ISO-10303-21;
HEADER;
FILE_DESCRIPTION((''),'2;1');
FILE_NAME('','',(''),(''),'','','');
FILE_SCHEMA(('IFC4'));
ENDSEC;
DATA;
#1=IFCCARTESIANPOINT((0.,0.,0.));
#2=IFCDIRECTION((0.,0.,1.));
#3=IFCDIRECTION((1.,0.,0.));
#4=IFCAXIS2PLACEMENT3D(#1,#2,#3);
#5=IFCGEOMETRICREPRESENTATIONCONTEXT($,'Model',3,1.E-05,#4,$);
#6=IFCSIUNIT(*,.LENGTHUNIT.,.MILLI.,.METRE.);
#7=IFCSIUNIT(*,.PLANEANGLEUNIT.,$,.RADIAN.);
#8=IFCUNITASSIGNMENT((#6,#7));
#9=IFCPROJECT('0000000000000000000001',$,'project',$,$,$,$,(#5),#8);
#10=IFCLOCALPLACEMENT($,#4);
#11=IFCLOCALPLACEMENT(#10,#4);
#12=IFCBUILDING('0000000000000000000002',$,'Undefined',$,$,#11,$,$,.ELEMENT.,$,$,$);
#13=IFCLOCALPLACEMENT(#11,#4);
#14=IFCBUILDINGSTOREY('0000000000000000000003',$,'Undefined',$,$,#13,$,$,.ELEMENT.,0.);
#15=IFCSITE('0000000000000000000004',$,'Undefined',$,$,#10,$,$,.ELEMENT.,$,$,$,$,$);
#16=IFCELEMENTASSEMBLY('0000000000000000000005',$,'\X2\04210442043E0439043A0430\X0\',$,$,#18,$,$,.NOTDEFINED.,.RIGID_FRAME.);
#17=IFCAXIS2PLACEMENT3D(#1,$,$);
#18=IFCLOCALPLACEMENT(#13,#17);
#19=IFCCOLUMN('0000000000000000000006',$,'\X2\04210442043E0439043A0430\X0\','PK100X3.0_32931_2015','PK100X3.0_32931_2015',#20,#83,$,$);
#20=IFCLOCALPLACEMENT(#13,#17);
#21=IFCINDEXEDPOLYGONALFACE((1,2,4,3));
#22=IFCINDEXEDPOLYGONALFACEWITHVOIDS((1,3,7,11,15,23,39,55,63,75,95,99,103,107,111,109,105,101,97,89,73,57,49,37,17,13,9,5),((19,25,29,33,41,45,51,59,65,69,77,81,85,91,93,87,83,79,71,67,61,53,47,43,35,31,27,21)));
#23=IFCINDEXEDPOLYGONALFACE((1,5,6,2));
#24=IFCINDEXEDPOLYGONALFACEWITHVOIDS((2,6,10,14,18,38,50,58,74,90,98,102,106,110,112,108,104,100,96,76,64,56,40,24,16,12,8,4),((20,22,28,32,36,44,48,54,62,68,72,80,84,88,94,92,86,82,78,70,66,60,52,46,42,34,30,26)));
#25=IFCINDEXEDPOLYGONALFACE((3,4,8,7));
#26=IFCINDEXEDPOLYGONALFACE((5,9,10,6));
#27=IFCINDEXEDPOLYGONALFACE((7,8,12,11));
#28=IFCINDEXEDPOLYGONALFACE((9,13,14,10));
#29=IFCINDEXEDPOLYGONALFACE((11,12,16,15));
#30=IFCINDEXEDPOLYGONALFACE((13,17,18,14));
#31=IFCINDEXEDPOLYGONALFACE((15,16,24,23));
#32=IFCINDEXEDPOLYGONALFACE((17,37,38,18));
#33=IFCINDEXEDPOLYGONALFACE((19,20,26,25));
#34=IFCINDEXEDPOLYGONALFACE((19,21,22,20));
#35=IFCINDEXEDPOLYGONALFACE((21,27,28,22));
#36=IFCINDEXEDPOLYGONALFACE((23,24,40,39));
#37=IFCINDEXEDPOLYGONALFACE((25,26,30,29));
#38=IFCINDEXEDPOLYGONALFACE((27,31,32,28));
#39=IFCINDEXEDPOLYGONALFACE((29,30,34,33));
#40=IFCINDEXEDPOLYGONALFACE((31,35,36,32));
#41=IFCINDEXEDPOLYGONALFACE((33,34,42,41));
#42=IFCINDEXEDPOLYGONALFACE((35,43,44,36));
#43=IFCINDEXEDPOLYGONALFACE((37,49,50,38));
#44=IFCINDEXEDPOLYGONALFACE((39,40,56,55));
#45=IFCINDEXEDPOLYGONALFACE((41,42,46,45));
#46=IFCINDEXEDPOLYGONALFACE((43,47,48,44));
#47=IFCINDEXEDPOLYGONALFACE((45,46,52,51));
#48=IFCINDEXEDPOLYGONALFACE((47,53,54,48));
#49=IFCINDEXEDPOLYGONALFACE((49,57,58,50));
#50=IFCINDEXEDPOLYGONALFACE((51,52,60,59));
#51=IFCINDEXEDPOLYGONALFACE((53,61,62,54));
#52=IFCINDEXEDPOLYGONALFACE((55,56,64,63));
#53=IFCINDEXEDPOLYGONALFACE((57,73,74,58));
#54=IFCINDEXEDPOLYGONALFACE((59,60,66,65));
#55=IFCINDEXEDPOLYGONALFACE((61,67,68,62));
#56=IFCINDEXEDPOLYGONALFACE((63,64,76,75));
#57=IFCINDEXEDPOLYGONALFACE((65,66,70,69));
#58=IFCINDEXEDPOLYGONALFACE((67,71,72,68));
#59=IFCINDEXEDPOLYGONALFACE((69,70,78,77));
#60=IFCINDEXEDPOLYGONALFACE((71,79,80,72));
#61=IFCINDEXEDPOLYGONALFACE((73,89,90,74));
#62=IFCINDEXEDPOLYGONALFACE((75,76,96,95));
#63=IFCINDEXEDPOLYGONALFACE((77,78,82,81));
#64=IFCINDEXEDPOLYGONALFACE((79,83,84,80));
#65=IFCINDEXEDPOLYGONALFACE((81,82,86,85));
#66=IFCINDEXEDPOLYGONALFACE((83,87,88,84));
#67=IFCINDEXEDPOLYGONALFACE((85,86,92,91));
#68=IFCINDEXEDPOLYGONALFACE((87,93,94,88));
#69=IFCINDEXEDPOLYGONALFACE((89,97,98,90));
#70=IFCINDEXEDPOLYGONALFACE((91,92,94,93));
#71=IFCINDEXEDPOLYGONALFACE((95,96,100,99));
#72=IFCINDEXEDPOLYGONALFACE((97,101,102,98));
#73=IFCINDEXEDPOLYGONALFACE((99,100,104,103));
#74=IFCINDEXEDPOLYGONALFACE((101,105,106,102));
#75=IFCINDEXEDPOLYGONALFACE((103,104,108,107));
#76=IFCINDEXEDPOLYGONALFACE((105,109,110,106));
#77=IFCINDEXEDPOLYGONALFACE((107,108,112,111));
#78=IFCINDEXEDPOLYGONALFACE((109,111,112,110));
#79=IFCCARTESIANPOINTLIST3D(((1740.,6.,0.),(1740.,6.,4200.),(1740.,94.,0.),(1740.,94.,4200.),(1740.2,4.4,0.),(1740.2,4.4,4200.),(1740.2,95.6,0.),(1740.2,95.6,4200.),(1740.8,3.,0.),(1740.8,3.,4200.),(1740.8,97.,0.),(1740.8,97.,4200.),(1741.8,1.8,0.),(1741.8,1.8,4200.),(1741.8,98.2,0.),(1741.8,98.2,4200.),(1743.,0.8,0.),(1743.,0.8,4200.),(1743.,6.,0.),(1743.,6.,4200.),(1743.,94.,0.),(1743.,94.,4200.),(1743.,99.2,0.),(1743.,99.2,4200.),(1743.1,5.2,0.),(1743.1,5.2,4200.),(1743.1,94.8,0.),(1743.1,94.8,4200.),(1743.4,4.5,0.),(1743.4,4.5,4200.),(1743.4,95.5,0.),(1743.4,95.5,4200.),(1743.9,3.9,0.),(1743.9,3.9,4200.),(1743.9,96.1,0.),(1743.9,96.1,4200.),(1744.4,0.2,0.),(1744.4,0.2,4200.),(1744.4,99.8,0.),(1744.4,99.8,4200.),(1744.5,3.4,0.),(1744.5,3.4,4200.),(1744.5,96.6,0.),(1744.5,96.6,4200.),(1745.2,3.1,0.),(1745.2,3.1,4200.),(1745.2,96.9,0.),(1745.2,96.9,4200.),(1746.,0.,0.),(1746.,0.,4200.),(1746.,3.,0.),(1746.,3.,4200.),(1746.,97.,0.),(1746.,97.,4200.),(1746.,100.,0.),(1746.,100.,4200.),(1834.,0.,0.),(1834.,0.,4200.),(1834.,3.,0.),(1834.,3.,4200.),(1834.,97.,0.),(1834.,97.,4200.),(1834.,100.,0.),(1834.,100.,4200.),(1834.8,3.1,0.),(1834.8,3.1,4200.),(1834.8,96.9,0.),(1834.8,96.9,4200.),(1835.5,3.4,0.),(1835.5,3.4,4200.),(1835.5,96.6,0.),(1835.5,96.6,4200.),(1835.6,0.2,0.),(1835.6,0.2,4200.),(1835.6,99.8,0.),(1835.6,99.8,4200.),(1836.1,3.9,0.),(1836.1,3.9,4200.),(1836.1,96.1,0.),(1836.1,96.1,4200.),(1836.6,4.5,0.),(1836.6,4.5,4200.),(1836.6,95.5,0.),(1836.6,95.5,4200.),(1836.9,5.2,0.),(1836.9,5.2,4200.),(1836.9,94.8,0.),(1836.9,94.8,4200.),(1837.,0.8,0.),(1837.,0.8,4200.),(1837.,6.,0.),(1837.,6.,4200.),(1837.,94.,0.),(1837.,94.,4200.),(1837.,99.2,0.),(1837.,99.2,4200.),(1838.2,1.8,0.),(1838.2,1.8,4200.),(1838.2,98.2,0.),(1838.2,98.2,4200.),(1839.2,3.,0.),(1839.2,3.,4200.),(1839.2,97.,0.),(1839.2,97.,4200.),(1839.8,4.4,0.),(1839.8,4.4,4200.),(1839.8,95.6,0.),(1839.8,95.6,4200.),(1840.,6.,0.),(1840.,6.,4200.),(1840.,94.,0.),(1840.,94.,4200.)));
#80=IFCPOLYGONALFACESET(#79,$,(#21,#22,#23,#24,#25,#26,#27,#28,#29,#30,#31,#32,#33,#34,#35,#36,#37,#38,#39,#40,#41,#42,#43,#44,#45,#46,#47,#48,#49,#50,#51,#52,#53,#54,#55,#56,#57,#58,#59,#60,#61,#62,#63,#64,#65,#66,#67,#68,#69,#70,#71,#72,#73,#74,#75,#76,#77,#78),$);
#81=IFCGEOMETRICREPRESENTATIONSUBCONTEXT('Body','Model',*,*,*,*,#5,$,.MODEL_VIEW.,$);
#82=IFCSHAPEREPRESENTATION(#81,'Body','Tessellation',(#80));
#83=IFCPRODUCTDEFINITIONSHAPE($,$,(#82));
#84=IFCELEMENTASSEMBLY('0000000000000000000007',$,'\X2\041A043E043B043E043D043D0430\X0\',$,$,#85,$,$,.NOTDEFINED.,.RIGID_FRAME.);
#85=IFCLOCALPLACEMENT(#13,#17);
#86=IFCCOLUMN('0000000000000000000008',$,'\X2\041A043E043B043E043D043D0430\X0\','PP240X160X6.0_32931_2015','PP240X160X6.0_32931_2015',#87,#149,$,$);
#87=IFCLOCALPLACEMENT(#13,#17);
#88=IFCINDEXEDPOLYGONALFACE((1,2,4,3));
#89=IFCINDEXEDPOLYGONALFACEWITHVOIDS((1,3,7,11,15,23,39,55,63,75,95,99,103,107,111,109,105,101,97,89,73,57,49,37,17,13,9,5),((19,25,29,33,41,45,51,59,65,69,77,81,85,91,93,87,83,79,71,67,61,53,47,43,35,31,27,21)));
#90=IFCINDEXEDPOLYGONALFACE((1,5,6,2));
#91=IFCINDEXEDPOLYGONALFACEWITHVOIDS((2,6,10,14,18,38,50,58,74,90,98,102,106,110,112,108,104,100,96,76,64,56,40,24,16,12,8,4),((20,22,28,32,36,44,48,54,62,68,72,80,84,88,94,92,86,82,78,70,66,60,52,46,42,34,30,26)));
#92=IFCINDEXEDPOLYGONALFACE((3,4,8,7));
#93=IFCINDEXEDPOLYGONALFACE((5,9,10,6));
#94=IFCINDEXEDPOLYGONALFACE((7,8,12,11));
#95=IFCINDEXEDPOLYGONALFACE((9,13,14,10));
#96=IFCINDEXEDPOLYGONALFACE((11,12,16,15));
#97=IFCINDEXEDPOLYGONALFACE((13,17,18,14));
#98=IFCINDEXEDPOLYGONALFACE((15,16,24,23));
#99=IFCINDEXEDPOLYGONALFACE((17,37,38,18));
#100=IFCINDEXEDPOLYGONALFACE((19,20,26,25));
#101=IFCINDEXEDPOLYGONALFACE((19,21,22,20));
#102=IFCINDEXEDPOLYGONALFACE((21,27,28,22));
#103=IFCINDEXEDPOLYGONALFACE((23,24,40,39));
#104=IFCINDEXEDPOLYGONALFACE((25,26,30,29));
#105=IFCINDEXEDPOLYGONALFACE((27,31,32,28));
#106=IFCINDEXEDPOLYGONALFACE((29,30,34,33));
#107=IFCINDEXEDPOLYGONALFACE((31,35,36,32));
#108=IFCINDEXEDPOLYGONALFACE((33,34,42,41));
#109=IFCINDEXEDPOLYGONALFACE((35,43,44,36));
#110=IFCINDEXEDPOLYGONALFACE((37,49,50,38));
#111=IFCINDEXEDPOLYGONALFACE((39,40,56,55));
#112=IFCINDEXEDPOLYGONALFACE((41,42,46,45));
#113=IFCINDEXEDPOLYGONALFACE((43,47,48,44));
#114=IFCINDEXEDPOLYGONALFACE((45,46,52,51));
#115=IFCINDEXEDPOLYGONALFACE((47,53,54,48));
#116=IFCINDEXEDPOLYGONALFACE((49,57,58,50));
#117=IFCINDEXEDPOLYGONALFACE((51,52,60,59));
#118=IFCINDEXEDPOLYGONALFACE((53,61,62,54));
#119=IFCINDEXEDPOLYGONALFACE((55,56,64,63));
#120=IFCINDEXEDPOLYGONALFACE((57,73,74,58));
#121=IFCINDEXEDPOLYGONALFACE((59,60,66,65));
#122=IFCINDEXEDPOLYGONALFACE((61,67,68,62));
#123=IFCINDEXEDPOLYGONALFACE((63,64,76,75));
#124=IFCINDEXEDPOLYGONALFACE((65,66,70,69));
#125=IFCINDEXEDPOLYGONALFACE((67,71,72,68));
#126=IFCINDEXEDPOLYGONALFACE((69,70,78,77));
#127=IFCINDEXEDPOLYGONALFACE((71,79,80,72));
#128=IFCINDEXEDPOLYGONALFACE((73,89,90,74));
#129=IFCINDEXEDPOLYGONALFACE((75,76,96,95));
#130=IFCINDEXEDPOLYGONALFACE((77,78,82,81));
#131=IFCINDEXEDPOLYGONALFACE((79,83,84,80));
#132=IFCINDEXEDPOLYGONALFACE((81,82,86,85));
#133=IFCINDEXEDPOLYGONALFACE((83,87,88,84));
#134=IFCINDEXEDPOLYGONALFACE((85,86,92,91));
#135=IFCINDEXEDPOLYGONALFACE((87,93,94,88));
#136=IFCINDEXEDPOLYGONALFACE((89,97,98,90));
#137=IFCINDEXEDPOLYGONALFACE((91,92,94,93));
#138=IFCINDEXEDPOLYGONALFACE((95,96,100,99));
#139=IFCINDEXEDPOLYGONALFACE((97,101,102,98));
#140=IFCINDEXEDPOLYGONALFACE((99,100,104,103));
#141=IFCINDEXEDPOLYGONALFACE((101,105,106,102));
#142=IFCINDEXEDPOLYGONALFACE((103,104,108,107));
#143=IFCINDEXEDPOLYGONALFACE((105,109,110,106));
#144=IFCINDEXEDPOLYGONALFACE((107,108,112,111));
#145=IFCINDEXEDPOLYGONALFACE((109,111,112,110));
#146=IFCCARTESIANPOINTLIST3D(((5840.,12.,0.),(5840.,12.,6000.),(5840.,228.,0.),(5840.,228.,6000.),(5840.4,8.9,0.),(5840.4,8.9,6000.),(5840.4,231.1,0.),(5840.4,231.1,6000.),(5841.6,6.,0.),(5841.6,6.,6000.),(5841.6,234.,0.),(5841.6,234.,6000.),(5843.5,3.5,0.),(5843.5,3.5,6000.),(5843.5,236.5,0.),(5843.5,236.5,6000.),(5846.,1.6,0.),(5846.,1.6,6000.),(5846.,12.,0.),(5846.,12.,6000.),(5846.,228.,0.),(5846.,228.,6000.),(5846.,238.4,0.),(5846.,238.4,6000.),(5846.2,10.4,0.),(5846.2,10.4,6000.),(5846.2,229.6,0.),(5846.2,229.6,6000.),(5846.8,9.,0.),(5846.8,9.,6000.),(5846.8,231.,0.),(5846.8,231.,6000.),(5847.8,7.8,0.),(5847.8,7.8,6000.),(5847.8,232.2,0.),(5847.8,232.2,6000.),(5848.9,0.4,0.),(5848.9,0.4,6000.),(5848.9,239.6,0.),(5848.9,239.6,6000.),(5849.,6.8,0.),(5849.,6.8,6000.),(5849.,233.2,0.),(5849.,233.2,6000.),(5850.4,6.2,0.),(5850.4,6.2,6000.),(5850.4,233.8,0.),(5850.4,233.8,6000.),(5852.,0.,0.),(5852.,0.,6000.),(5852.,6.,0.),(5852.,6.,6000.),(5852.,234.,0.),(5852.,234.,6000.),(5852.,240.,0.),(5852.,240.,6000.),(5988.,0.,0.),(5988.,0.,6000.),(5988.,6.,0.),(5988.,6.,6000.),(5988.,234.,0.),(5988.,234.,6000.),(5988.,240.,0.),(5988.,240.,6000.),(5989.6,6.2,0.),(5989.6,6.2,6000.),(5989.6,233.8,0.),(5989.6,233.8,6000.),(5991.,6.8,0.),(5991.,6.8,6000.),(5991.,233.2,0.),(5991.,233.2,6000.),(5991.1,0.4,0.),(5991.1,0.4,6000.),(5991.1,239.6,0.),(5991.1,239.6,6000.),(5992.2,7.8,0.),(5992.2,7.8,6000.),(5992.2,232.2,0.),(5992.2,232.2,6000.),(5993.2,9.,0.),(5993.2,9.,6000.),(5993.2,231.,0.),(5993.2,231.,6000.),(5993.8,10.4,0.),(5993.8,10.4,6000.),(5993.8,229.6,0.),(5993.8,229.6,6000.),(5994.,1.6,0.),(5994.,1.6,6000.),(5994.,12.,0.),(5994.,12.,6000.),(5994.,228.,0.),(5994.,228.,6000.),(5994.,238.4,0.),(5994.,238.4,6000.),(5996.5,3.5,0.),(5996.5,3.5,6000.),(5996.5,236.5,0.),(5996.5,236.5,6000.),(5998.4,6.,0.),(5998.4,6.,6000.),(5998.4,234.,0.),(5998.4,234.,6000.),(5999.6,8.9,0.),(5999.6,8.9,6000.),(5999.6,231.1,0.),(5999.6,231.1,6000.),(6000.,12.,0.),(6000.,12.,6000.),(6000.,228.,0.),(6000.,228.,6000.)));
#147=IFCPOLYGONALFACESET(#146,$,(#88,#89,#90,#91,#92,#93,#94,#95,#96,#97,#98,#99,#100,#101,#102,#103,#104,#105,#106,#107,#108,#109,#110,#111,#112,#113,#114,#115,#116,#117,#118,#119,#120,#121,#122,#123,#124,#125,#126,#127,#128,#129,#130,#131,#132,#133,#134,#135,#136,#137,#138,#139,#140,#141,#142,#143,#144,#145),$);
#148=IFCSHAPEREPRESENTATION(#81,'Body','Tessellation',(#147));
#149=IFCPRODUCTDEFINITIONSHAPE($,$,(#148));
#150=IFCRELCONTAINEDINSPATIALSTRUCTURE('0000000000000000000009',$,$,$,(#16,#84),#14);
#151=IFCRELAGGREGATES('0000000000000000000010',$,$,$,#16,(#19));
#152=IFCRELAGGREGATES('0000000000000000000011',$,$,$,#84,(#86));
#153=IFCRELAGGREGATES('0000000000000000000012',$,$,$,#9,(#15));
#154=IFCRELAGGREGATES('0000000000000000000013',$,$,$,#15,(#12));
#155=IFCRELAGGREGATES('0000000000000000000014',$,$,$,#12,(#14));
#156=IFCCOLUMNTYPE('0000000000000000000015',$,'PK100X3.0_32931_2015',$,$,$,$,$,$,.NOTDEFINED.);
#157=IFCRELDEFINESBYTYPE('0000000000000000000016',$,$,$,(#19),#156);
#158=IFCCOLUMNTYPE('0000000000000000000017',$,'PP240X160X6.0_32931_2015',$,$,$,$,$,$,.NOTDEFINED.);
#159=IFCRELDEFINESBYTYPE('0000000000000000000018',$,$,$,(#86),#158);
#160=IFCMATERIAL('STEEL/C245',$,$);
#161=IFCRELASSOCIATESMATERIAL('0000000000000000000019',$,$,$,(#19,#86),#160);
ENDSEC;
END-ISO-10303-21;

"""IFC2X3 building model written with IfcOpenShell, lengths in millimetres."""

from ifc_helpers import new_model, si_unit, frame, origin_with_axes, origin_2d_with_axis, place, context, subcontext, project, spatial, hollow_rectangle, extrude, material, type_object, element, aggregate, save


model = new_model("IFC2X3")

# Units and contexts
model_context = context("Model", 3, precision=1e-05, world=origin_with_axes())
body_context = subcontext(model_context, "Body", "Model", "MODEL_VIEW")
ifc_project = project(units=[si_unit("LENGTHUNIT", "METRE", prefix="MILLI"), si_unit("PLANEANGLEUNIT", "RADIAN")], contexts=[model_context])

# Site, building, storey
site_placement = place(None, origin_with_axes())
site = spatial("IfcSite", under=ifc_project, at=site_placement, Name="Undefined", CompositionType="ELEMENT")
building_placement = place(site_placement, origin_with_axes())
building = spatial("IfcBuilding", under=site, at=building_placement, Name="Undefined", CompositionType="ELEMENT")
storey_placement = place(building_placement, origin_with_axes())
storey = spatial("IfcBuildingStorey", under=building, at=storey_placement, Name="Undefined", CompositionType="ELEMENT", Elevation=0.0)

# Element assemblies, columns
ifc_material = material(Name="STEEL/C245")
assembly_1_placement = place(storey_placement, origin_with_axes())
assembly_1 = element("IfcElementAssembly", 1, at=assembly_1_placement, inside=storey, Name="Стойка", AssemblyPlace="NOTDEFINED", PredefinedType="RIGID_FRAME")
column_type_1 = type_object("IfcColumnType", Name="PK100X3.0_32931_2015", PredefinedType="NOTDEFINED")
column_1_placement = place(assembly_1_placement, frame((1790.0, 50.0, 0.0), z_axis=(0.0, 0.0, 1.0), x_axis=(0.0, 1.0, 0.0)))
column_1 = element("IfcColumn", 2, at=column_1_placement, type_object=column_type_1, material=ifc_material, Name="Стойка", Description="PK100X3.0_32931_2015", ObjectType="PK100X3.0_32931_2015", context=body_context, shape_type="SweptSolid", body=[
    extrude(hollow_rectangle(XDim=100.0, YDim=100.0, WallThickness=3.0, InnerFilletRadius=3.0, OuterFilletRadius=6.0, at=origin_2d_with_axis()), frame((0.0, 0.0, 4200.0), z_axis=(0.0, 0.0, -1.0), x_axis=(0.0, 1.0, 0.0)), (0.0, 0.0, 1.0), 4200.0),
])
aggregate(assembly_1, [column_1])
assembly_2_placement = place(storey_placement, origin_with_axes())
assembly_2 = element("IfcElementAssembly", 3, at=assembly_2_placement, inside=storey, Name="Колонна", AssemblyPlace="NOTDEFINED", PredefinedType="RIGID_FRAME")
column_type_2 = type_object("IfcColumnType", Name="PP240X160X6.0_32931_2015", PredefinedType="NOTDEFINED")
column_2_placement = place(assembly_2_placement, frame((5920.0, 120.0, 0.0), z_axis=(0.0, 0.0, 1.0), x_axis=(0.0, 1.0, 0.0)))
column_2 = element("IfcColumn", 4, at=column_2_placement, type_object=column_type_2, material=ifc_material, Name="Колонна", Description="PP240X160X6.0_32931_2015", ObjectType="PP240X160X6.0_32931_2015", context=body_context, shape_type="SweptSolid", body=[
    extrude(hollow_rectangle(XDim=160.0, YDim=240.0, WallThickness=6.0, InnerFilletRadius=6.0, OuterFilletRadius=12.0, at=origin_2d_with_axis()), frame((0.0, 0.0, 6000.0), z_axis=(0.0, 0.0, -1.0), x_axis=(0.0, 1.0, 0.0)), (0.0, 0.0, 1.0), 6000.0),
])
aggregate(assembly_2, [column_2])

save(model, "model.ifc")
